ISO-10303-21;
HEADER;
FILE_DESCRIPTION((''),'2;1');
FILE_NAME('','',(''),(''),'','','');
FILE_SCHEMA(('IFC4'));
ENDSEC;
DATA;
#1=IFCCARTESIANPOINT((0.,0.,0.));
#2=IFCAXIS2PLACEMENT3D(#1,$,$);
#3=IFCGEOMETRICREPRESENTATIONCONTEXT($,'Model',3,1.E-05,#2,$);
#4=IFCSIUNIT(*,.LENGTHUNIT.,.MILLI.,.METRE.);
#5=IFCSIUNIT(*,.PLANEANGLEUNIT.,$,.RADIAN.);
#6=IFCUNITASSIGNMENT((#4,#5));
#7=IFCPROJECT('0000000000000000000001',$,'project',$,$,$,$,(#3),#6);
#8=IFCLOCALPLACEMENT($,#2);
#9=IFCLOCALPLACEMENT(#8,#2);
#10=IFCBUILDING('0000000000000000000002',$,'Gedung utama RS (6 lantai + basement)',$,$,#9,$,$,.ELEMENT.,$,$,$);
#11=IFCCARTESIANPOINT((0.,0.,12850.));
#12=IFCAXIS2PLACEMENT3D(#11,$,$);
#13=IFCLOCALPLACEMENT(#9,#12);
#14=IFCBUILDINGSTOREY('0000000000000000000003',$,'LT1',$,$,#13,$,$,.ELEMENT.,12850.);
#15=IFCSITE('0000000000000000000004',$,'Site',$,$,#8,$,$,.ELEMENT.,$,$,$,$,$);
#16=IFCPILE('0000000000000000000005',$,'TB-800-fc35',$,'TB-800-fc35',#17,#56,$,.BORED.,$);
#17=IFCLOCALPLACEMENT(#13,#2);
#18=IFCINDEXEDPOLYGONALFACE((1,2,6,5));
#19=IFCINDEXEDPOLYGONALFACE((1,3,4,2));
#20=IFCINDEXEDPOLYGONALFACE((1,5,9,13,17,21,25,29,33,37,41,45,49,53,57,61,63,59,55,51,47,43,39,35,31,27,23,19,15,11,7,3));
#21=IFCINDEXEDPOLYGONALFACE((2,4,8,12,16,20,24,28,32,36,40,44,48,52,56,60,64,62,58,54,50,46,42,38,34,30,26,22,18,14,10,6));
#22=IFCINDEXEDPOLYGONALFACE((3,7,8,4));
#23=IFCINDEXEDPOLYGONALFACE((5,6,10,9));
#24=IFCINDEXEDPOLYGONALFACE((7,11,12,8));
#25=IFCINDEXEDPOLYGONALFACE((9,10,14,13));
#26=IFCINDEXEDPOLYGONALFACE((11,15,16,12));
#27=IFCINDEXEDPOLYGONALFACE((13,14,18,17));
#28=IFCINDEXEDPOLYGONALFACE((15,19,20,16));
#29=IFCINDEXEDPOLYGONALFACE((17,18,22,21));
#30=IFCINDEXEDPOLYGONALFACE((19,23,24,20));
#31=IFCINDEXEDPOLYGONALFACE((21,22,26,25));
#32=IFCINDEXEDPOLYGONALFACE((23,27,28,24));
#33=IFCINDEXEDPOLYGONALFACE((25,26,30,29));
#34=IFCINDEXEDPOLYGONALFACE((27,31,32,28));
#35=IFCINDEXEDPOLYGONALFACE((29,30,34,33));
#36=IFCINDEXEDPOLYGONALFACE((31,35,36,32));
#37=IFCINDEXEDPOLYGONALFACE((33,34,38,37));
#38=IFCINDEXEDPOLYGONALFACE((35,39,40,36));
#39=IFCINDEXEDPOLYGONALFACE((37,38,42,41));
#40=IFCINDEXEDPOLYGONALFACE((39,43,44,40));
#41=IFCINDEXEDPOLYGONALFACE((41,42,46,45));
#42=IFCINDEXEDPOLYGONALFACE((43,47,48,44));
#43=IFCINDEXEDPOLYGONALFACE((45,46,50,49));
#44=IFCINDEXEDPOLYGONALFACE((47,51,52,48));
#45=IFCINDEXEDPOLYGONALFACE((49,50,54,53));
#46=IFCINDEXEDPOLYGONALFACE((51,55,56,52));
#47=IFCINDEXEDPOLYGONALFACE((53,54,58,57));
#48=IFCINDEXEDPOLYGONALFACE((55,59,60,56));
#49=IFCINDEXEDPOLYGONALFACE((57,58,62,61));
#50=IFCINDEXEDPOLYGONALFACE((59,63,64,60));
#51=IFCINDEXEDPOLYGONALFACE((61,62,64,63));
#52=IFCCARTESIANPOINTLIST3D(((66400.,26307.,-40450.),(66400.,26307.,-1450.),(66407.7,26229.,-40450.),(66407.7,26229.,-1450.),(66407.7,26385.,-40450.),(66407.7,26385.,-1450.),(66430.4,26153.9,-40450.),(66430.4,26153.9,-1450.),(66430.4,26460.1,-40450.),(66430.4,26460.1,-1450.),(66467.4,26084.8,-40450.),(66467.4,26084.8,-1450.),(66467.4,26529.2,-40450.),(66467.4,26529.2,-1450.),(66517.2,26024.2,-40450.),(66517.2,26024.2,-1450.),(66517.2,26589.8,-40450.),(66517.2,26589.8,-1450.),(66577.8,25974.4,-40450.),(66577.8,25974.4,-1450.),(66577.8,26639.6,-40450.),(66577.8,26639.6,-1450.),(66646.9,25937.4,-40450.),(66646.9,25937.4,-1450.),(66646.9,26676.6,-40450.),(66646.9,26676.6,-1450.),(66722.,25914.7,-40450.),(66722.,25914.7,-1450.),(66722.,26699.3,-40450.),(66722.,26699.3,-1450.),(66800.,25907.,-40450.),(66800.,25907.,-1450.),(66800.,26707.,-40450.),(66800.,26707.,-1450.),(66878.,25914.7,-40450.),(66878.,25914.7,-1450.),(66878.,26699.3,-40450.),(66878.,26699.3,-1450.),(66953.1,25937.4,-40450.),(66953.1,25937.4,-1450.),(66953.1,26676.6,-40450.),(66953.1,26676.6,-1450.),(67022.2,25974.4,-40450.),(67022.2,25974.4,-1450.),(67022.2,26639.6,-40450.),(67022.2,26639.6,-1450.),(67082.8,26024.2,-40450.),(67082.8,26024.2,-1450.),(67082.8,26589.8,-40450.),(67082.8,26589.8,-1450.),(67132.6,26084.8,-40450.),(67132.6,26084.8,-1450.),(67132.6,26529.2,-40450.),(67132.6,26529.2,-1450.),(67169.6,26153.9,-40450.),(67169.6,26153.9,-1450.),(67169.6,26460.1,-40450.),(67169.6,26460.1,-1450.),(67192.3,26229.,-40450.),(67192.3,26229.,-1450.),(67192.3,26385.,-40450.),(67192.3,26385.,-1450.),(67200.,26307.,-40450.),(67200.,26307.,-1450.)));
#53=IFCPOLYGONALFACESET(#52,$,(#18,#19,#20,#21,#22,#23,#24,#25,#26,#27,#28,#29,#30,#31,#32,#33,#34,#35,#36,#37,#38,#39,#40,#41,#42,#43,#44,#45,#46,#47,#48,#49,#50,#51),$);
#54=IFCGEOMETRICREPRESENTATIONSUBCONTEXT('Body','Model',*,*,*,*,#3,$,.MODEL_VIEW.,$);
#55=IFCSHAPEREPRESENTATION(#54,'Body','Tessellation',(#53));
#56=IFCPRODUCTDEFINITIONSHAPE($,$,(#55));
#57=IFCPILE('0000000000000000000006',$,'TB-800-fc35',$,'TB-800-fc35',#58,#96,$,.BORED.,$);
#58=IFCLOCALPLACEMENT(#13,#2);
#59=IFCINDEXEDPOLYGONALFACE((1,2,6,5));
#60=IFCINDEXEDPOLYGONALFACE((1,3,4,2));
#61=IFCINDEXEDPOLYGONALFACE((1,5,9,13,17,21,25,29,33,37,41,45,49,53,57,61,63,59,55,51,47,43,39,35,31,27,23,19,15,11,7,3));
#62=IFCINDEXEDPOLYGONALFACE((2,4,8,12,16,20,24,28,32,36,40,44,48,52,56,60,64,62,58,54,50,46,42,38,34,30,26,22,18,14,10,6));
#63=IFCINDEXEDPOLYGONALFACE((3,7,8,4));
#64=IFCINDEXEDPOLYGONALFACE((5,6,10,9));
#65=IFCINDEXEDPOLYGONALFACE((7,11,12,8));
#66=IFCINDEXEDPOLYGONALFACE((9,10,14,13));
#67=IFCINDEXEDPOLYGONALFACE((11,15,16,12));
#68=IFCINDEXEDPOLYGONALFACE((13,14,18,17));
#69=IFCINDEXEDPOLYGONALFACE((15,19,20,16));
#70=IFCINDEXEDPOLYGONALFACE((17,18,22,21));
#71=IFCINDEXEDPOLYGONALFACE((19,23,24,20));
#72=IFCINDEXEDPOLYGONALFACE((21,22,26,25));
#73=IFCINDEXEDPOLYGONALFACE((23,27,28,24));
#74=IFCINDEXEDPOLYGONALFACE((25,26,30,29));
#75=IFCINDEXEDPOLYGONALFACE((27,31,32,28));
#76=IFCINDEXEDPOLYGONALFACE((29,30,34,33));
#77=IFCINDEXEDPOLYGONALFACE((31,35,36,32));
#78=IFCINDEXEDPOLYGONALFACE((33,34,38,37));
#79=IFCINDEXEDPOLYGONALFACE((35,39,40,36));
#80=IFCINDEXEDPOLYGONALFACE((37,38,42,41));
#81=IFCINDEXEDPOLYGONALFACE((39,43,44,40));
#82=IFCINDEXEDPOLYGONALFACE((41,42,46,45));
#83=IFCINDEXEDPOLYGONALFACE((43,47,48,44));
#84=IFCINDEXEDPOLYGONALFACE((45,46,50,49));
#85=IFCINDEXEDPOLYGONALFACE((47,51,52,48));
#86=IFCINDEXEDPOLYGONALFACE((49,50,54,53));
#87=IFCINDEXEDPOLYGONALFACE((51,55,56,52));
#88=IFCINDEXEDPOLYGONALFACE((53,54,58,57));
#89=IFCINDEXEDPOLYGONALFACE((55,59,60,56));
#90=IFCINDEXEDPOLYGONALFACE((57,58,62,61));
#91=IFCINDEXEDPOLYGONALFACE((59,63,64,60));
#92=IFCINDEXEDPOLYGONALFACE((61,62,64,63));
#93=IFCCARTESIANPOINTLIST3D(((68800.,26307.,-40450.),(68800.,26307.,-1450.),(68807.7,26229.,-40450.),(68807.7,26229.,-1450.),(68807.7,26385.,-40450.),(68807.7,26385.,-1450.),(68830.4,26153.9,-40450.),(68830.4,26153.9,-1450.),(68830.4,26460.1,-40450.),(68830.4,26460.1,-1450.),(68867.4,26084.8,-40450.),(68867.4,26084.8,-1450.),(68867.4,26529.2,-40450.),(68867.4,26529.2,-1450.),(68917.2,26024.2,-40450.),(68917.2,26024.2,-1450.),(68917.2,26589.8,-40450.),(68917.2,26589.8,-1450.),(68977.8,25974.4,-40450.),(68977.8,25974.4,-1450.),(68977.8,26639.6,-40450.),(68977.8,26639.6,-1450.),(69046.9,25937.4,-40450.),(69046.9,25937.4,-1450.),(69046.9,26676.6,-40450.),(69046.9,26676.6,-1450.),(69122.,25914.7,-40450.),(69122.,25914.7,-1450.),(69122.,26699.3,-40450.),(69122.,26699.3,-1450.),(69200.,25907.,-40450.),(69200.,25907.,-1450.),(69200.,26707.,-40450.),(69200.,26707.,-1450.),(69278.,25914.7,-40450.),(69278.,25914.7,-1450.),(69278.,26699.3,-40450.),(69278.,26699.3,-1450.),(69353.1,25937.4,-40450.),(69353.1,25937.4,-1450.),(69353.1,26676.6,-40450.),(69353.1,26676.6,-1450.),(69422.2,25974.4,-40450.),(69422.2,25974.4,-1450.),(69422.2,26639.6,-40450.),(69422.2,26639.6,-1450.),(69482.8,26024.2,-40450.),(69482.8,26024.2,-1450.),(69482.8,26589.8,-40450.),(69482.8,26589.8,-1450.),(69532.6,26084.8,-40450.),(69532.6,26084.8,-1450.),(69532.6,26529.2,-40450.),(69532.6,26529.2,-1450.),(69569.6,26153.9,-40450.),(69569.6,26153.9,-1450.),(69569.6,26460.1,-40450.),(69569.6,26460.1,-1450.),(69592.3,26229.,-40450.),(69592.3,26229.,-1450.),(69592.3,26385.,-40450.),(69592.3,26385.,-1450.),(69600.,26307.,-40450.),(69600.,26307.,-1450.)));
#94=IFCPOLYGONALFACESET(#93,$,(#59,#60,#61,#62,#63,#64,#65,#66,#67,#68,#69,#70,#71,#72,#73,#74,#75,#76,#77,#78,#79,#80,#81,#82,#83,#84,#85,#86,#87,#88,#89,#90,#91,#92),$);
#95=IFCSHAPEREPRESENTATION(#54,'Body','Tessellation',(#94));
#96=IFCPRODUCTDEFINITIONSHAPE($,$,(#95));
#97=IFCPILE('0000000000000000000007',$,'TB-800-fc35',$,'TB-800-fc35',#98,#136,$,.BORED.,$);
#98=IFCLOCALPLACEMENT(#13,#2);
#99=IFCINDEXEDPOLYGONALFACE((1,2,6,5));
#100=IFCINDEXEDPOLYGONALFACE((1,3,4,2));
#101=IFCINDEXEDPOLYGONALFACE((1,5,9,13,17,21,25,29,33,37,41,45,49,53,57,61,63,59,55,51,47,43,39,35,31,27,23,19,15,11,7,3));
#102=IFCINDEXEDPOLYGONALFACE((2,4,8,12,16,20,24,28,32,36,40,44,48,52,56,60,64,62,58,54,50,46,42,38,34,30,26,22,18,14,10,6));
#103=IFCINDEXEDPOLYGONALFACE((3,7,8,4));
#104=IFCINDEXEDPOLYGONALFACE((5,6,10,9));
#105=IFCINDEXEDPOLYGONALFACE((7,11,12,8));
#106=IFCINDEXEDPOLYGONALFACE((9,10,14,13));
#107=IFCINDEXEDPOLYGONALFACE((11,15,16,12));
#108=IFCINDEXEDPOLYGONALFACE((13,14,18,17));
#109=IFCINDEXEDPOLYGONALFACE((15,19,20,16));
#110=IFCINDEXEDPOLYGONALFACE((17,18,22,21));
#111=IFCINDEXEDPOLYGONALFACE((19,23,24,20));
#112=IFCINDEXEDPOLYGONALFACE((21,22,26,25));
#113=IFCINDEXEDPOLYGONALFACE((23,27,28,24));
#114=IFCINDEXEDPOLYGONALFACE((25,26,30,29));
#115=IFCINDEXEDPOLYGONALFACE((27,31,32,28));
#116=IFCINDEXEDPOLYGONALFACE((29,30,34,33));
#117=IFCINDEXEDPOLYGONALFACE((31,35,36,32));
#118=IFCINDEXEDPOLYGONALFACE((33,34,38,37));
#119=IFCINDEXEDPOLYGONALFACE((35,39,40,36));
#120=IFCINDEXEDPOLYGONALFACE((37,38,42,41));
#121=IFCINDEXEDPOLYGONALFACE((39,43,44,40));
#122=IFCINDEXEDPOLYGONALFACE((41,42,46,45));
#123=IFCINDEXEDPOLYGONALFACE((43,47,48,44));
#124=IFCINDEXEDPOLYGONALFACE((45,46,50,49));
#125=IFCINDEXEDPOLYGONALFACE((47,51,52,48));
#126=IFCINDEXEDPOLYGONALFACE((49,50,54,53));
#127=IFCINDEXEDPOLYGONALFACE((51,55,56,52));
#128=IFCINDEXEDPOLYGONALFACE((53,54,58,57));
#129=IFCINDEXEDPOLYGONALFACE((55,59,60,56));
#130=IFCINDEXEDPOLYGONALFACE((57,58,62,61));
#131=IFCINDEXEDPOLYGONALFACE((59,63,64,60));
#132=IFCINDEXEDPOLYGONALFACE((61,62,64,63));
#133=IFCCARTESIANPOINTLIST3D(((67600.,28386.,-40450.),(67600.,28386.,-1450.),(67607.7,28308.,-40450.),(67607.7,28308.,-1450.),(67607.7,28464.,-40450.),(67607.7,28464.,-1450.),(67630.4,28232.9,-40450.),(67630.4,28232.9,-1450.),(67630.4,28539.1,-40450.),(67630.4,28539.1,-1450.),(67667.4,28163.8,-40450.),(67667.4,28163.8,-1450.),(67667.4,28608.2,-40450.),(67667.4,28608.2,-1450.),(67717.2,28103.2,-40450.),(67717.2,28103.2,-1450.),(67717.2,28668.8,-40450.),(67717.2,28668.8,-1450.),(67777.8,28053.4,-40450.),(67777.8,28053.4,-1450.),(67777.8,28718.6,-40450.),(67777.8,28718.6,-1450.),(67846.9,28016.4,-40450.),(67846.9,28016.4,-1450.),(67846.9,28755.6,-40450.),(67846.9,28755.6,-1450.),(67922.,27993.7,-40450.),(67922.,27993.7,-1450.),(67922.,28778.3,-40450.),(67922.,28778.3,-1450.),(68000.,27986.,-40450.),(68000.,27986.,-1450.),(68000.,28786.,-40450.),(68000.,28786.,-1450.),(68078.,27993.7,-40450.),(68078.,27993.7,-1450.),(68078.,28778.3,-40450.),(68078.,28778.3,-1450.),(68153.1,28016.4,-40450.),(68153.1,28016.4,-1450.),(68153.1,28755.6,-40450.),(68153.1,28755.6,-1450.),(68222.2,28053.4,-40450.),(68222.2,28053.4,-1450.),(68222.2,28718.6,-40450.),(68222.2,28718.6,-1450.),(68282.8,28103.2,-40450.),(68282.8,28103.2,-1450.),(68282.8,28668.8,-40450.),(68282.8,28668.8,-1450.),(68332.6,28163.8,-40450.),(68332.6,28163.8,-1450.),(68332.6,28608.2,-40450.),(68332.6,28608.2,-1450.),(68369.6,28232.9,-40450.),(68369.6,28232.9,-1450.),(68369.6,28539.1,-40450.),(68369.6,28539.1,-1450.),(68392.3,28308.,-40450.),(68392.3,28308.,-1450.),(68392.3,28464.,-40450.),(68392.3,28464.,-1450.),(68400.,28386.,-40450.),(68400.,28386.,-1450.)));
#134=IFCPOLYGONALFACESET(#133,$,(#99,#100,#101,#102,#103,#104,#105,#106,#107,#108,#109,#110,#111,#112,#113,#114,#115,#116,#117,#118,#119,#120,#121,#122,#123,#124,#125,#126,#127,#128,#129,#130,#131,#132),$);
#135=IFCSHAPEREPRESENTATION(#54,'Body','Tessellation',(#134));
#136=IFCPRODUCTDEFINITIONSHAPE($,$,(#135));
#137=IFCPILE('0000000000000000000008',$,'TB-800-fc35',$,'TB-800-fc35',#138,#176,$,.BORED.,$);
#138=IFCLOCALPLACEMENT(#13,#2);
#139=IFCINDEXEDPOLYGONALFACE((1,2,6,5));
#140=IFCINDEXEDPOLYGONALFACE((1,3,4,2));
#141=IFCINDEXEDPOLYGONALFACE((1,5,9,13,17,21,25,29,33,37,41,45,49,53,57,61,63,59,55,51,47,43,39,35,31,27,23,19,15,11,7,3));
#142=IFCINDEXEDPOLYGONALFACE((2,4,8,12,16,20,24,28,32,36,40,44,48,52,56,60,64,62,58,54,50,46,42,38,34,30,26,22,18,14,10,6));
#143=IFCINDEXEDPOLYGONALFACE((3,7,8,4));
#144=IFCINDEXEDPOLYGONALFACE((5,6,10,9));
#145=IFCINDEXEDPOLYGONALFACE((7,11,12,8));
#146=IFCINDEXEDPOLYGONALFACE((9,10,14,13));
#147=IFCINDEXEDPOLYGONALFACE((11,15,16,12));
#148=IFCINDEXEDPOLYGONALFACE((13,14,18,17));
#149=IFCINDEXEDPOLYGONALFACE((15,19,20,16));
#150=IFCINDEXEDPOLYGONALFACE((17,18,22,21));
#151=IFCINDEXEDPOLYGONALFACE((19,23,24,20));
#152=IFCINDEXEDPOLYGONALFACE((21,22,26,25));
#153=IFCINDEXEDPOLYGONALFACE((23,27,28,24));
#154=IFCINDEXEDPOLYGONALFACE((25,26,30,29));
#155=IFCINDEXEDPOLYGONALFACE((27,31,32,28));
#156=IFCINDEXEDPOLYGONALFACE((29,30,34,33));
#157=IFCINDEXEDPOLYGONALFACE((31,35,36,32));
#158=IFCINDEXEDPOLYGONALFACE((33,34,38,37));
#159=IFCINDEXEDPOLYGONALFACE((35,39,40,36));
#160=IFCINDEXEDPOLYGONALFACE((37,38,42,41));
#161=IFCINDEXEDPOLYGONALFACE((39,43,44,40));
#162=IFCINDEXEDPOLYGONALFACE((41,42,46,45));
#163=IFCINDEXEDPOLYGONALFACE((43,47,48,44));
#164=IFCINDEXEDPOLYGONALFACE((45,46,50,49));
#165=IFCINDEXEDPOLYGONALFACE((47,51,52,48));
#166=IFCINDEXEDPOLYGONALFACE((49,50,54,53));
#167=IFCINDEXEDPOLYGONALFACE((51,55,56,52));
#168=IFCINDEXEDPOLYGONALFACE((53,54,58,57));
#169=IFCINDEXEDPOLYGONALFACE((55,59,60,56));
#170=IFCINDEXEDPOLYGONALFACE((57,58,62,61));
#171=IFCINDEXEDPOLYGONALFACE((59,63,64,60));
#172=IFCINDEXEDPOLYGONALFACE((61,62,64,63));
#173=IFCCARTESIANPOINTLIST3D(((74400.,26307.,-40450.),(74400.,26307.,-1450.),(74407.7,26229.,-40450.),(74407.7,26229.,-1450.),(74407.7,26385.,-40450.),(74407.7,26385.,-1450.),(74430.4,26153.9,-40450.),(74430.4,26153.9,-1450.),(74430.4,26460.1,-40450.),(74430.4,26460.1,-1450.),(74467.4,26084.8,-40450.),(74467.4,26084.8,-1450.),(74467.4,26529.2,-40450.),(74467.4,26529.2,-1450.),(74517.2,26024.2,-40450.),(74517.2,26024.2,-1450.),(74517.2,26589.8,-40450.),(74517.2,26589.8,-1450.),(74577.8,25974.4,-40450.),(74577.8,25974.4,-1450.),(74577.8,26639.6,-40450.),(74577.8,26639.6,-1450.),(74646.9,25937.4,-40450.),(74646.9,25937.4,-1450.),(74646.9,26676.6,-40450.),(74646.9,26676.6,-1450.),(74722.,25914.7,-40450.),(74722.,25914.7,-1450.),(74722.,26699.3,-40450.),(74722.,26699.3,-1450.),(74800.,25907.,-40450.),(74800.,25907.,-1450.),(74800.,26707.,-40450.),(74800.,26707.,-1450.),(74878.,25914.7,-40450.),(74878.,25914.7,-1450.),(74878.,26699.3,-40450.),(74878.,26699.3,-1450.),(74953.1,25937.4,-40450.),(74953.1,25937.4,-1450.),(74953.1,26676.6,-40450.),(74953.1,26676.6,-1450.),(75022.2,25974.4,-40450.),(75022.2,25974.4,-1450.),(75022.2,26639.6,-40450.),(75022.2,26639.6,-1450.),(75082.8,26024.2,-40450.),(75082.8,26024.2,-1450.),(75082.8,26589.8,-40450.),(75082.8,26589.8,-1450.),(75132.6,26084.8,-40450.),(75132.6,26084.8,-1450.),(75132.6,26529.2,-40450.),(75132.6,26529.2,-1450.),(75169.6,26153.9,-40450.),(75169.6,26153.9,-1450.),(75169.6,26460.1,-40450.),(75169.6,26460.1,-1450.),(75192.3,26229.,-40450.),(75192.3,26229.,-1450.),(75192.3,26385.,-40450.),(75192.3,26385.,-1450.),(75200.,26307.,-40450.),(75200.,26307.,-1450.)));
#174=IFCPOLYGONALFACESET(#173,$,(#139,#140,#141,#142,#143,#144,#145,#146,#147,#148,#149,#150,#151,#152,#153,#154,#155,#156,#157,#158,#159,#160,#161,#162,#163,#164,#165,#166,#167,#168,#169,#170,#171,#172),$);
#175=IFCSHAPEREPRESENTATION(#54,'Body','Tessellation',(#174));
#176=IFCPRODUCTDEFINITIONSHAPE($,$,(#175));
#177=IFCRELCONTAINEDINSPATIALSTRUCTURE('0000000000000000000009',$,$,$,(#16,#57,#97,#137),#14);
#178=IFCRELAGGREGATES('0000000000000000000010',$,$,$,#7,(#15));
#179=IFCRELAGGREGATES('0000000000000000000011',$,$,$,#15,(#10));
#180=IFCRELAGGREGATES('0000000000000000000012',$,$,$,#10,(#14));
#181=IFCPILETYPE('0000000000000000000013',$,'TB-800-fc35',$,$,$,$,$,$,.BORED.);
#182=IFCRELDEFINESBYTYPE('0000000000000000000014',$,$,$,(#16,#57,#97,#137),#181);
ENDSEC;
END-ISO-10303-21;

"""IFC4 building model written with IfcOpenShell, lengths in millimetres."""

from ifc_helpers import new_model, si_unit, frame, origin, origin_2d, place, context, subcontext, project, spatial, circle, extrude, material_profile, profile_set, profile_usage, type_object, element, save


model = new_model("IFC4")

# Units and contexts
model_context = context("Model", 3, precision=1e-05, world=origin())
body_context = subcontext(model_context, "Body", "Model", "MODEL_VIEW")
ifc_project = project(units=[si_unit("LENGTHUNIT", "METRE", prefix="MILLI"), si_unit("PLANEANGLEUNIT", "RADIAN")], contexts=[model_context])

# Site, building, storey
site_placement = place(None, origin())
site = spatial("IfcSite", under=ifc_project, at=site_placement, Name="Site", CompositionType="ELEMENT")
building_placement = place(site_placement, origin())
building = spatial("IfcBuilding", under=site, at=building_placement, Name="Gedung utama RS (6 lantai + basement)", CompositionType="ELEMENT")
storey_placement = place(building_placement, frame((0.0, 0.0, 12850.0)))
storey = spatial("IfcBuildingStorey", under=building, at=storey_placement, Name="LT1", CompositionType="ELEMENT", Elevation=12850.0)

# Piles
ifc_material_profile = material_profile(None, circle(Radius=400.0, at=origin_2d()), Name="TB-800-fc35")
ifc_profile_set = profile_set([ifc_material_profile], Name="TB-800-fc35")
ifc_profile_usage = profile_usage(ifc_profile_set, cardinal=5)
pile_type = type_object("IfcPileType", Name="TB-800-fc35", PredefinedType="BORED", material=ifc_profile_set)
for number, where, z_axis, x_axis, name in (
    (1, (66800.0, 26307.0, -40450.0), (0.0, 0.0, 1.0), (1.0, 0.0, 0.0), "TB-800-fc35"),
    (2, (69200.0, 26307.0, -40450.0), (0.0, 0.0, 1.0), (1.0, 0.0, 0.0), "TB-800-fc35"),
    (3, (68000.0, 28386.0, -40450.0), (0.0, 0.0, 1.0), (1.0, 0.0, 0.0), "TB-800-fc35"),
    (4, (74800.0, 26307.0, -40450.0), (0.0, 0.0, 1.0), (1.0, 0.0, 0.0), "TB-800-fc35"),
):
    element("IfcPile", number, at=place(storey_placement, frame(where, z_axis=z_axis, x_axis=x_axis)), inside=storey, type_object=pile_type, material=ifc_profile_usage, Name=name, ObjectType="TB-800-fc35", PredefinedType="BORED", context=body_context, shape_type="SweptSolid", body=[
        extrude(circle(Radius=400.0, at=origin_2d()), origin(), (0.0, 0.0, 1.0), 39000.0),
    ])

save(model, "model.ifc")
